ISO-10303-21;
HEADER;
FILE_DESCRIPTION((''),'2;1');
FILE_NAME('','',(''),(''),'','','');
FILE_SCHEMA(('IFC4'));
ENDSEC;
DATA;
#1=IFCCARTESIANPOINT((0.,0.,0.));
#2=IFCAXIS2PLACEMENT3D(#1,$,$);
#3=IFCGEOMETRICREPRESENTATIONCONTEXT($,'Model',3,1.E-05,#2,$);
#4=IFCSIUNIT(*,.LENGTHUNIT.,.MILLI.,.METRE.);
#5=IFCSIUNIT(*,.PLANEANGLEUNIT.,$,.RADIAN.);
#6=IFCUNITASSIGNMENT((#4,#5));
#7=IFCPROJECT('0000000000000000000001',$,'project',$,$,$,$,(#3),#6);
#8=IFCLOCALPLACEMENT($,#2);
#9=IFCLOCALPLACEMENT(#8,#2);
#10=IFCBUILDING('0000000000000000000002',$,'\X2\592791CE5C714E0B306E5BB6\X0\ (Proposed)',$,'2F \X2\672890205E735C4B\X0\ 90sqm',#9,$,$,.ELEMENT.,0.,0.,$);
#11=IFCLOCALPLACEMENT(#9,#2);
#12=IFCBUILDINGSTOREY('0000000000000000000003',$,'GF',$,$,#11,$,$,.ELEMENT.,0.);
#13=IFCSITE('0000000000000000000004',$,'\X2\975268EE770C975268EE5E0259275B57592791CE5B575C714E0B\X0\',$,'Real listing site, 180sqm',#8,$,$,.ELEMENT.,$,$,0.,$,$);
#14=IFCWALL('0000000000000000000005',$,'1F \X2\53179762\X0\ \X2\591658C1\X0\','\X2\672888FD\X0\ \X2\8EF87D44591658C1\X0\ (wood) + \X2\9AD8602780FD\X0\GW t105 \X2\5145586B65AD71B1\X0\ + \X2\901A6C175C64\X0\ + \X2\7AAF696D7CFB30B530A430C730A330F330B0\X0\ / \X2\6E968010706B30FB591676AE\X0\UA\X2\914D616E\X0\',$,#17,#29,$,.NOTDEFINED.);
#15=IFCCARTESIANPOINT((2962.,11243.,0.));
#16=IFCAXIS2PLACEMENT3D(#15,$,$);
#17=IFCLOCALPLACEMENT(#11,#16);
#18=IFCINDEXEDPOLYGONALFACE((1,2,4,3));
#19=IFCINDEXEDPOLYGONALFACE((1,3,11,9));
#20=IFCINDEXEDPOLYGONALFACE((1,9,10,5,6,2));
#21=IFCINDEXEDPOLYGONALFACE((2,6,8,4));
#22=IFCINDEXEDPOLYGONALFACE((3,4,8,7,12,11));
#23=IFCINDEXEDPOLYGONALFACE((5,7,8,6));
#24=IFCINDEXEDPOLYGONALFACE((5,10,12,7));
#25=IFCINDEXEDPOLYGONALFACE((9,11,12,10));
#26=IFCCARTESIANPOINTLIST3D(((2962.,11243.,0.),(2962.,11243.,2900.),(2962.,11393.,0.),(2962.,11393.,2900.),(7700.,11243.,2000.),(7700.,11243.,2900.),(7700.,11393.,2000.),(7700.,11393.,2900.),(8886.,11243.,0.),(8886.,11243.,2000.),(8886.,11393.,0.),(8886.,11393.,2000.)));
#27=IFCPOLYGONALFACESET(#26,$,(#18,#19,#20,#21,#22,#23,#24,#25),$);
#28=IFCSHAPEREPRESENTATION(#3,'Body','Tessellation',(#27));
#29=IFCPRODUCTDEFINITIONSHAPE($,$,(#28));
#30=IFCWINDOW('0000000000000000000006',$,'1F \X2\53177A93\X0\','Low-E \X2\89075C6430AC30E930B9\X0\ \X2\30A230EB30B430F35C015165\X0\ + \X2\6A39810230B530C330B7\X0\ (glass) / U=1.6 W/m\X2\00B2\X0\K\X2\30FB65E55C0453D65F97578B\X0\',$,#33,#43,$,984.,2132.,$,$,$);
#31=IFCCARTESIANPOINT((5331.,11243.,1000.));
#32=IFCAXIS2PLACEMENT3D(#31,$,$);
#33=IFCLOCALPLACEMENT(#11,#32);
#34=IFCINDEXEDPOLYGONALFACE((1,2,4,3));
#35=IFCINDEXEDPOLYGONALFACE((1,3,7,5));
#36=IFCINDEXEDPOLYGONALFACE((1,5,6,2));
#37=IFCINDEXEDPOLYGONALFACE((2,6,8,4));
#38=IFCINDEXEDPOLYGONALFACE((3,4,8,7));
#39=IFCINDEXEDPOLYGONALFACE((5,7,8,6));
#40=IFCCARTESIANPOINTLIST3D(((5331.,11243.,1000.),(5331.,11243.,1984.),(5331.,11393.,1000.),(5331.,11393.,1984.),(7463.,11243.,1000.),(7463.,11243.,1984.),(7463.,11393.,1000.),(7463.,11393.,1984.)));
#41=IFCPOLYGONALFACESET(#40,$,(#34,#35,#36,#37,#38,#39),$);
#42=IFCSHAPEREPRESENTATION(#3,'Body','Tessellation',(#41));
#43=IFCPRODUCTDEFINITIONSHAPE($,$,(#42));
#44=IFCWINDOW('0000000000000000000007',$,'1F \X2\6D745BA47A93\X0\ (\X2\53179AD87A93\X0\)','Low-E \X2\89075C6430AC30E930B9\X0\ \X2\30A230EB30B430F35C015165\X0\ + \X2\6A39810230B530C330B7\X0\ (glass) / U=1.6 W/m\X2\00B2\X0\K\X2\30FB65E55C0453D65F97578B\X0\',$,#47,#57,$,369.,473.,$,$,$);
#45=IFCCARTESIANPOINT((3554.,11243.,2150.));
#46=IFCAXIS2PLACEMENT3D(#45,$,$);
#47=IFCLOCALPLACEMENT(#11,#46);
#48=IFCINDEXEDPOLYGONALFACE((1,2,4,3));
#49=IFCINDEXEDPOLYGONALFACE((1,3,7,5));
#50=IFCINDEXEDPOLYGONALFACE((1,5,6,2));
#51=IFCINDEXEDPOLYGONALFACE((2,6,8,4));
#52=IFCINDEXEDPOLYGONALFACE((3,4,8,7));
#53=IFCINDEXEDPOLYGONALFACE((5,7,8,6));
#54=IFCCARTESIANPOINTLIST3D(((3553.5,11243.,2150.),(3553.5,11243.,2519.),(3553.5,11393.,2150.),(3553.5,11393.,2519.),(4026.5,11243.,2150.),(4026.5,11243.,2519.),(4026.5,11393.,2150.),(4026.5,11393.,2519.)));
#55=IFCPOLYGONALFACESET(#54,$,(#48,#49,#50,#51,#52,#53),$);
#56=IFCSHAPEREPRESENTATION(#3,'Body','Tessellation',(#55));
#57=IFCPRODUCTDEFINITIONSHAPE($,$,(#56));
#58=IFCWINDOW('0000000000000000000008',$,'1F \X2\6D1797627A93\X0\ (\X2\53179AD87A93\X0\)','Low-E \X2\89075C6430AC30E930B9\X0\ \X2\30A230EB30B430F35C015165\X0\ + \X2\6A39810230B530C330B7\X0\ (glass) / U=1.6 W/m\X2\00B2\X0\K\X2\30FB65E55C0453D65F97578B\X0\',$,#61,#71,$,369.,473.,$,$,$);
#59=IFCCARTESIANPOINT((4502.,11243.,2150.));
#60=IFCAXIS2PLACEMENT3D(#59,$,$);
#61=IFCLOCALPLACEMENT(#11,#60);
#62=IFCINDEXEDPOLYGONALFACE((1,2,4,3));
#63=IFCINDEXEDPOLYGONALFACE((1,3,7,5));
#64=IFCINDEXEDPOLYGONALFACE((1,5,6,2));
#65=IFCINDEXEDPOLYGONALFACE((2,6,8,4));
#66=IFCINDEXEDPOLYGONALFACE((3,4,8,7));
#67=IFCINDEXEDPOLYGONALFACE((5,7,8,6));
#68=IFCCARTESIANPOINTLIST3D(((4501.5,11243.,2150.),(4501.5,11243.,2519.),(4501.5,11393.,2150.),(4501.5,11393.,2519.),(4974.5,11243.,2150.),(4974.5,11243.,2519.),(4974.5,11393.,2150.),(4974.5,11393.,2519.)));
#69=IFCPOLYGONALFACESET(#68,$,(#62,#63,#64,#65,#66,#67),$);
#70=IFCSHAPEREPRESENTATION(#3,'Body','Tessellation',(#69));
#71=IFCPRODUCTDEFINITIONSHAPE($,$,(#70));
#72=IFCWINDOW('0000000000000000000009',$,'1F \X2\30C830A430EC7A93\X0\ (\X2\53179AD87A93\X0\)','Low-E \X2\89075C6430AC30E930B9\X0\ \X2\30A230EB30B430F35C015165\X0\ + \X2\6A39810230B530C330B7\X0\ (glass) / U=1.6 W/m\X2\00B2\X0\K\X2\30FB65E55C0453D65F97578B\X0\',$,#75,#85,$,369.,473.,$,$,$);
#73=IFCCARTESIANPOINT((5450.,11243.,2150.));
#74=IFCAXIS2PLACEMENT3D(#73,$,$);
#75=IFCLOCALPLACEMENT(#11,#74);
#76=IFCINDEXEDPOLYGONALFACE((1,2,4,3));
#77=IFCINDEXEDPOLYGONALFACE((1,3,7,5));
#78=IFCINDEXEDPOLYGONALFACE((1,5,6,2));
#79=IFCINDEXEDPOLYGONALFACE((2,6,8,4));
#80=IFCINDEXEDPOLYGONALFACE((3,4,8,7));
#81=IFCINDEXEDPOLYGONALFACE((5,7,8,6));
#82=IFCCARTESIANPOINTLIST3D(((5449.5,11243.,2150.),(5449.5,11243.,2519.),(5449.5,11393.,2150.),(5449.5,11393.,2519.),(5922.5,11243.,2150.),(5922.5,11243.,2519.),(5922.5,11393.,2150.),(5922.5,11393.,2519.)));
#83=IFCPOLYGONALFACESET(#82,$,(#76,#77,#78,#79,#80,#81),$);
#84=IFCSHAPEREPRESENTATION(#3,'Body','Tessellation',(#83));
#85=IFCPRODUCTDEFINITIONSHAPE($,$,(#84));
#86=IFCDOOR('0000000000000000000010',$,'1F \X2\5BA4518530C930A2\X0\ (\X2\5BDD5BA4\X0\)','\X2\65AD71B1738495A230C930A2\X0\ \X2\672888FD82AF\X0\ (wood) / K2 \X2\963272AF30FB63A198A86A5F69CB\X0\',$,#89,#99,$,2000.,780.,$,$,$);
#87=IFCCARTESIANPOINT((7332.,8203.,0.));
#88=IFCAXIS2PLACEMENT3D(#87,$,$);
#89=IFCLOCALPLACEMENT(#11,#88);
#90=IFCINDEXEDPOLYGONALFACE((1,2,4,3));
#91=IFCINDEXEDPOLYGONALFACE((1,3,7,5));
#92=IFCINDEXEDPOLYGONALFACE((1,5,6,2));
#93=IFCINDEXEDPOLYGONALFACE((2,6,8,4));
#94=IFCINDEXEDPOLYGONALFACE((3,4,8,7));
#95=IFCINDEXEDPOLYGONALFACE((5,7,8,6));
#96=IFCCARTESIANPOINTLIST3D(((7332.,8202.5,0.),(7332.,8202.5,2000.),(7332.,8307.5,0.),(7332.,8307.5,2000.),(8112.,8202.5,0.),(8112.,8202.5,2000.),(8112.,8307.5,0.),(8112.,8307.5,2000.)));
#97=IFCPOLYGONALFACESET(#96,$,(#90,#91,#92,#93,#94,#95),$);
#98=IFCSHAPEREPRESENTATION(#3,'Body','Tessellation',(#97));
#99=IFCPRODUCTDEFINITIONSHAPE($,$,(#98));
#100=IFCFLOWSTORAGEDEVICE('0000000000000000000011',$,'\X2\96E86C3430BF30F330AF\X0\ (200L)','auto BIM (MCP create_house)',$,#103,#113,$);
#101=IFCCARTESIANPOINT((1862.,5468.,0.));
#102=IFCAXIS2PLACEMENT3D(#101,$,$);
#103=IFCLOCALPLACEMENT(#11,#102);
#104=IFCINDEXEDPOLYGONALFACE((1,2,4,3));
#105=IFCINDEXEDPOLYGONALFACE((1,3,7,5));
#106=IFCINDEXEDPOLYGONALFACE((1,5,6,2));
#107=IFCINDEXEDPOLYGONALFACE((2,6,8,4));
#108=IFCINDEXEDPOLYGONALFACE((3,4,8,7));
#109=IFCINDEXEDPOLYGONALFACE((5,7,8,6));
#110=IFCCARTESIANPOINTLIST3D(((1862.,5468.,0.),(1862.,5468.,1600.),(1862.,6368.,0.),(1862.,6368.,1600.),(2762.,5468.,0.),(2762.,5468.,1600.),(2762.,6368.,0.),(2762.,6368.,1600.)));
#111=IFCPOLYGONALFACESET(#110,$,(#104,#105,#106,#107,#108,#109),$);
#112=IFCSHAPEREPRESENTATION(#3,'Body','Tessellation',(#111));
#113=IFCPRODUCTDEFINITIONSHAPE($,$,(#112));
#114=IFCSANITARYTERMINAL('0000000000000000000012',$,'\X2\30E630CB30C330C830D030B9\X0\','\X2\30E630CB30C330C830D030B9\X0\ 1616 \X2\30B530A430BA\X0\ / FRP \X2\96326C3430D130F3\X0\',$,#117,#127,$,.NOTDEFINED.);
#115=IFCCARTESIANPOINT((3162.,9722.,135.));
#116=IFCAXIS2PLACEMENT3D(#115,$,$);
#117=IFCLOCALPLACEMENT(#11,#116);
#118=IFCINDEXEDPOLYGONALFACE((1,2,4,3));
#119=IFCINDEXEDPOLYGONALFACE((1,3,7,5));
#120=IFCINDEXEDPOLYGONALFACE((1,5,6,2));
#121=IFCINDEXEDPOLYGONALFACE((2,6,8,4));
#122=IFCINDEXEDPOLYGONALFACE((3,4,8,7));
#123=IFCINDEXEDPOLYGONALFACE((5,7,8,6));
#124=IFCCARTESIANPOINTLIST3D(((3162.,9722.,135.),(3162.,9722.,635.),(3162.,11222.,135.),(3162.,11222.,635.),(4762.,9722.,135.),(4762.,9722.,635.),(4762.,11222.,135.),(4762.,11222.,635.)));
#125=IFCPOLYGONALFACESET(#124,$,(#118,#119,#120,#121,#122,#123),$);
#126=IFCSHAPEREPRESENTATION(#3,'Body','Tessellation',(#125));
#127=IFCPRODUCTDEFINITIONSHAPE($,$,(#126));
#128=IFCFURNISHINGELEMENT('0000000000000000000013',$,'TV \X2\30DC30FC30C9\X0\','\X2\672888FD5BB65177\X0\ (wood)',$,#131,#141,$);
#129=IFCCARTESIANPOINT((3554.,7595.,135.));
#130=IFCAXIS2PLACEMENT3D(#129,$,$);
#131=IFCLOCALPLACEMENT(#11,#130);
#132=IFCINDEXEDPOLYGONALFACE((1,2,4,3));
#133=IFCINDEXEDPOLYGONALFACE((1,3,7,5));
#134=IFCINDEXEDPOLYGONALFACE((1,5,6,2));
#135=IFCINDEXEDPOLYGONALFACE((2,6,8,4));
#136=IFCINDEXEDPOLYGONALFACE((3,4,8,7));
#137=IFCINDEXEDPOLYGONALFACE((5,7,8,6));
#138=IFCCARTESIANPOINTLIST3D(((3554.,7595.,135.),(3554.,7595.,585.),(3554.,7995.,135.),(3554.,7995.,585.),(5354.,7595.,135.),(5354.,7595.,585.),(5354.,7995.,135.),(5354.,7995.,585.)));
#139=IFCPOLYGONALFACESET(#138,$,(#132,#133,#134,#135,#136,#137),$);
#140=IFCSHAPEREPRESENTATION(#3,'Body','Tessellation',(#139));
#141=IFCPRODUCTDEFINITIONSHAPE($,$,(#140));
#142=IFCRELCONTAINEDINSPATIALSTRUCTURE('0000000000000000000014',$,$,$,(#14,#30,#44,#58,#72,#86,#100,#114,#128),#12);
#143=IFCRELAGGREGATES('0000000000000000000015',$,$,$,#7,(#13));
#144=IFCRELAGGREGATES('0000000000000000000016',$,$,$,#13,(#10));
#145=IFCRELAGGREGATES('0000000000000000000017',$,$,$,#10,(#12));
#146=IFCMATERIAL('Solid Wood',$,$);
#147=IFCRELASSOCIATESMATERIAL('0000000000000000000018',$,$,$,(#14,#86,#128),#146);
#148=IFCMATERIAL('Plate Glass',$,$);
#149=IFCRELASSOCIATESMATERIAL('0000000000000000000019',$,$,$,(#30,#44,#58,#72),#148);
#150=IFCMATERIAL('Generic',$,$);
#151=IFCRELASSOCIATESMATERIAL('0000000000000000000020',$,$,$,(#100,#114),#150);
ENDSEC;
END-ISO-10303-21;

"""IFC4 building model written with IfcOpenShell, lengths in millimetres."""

from ifc_helpers import new_model, si_unit, frame, frame_2d, origin, place, context, project, spatial, rectangle, extrude, material, element, fill, save


model = new_model("IFC4")

# Units and contexts
model_context = context("Model", 3, precision=1e-05, world=origin())
ifc_project = project(units=[si_unit("LENGTHUNIT", "METRE", prefix="MILLI"), si_unit("PLANEANGLEUNIT", "RADIAN")], contexts=[model_context])

# Site, building, storey
site_placement = place(None, origin())
site = spatial("IfcSite", under=ifc_project, at=site_placement, Name="青森県青森市大字大野字山下", ObjectType="Real listing site, 180sqm", CompositionType="ELEMENT", RefElevation=0.0)
building_placement = place(site_placement, origin())
building = spatial("IfcBuilding", under=site, at=building_placement, Name="大野山下の家 (Proposed)", ObjectType="2F 木造平屋 90sqm", CompositionType="ELEMENT", ElevationOfRefHeight=0.0, ElevationOfTerrain=0.0)
storey_placement = place(building_placement, origin())
storey = spatial("IfcBuildingStorey", under=building, at=storey_placement, Name="GF", CompositionType="ELEMENT", Elevation=0.0)

# Wall, openings, windows
ifc_material_1 = material(Name="Solid Wood")
wall_1_placement = place(storey_placement, frame((2962.0, 11243.0, 0.0)))
wall_1 = element("IfcWall", 1, at=wall_1_placement, inside=storey, material=ifc_material_1, Name="1F 北面 外壁", Description="木製 軸組外壁 (wood) + 高性能GW t105 充填断熱 + 通気層 + 窯業系サイディング / 準耐火・外皮UA配慮", PredefinedType="NOTDEFINED", context=model_context, shape_type="SweptSolid", body=[
    extrude(rectangle(XDim=5924.0, YDim=150.0, at=frame_2d((2962.0, 75.0))), frame((2962.0, 11243.0, 0.0)), (0.0, 0.0, 1.0), 2900.0),
])
opening_1_placement = place(storey_placement, frame((5331.0, 11243.0, 1000.0)))
opening_1 = element("IfcOpeningElement", 2, at=opening_1_placement, cuts=wall_1, PredefinedType="NOTDEFINED", context=model_context, shape_type="SweptSolid", body=[
    extrude(rectangle(XDim=2132.0, YDim=150.0, at=frame_2d((1066.0, 75.0))), frame((5331.0, 11243.0, 1000.0)), (0.0, 0.0, 1.0), 984.0),
])
opening_2_placement = place(storey_placement, frame((3554.0, 11243.0, 2150.0)))
opening_2 = element("IfcOpeningElement", 3, at=opening_2_placement, cuts=wall_1, PredefinedType="NOTDEFINED", context=model_context, shape_type="SweptSolid", body=[
    extrude(rectangle(XDim=473.0, YDim=150.0, at=frame_2d((236.0, 75.0))), frame((3554.0, 11243.0, 2150.0)), (0.0, 0.0, 1.0), 369.0),
])
opening_3_placement = place(storey_placement, frame((4502.0, 11243.0, 2150.0)))
opening_3 = element("IfcOpeningElement", 4, at=opening_3_placement, cuts=wall_1, PredefinedType="NOTDEFINED", context=model_context, shape_type="SweptSolid", body=[
    extrude(rectangle(XDim=473.0, YDim=150.0, at=frame_2d((236.0, 75.0))), frame((4502.0, 11243.0, 2150.0)), (0.0, 0.0, 1.0), 369.0),
])
opening_4_placement = place(storey_placement, frame((5450.0, 11243.0, 2150.0)))
opening_4 = element("IfcOpeningElement", 5, at=opening_4_placement, cuts=wall_1, PredefinedType="NOTDEFINED", context=model_context, shape_type="SweptSolid", body=[
    extrude(rectangle(XDim=473.0, YDim=150.0, at=frame_2d((236.0, 75.0))), frame((5450.0, 11243.0, 2150.0)), (0.0, 0.0, 1.0), 369.0),
])
ifc_material_2 = material(Name="Plate Glass")
window_1_placement = place(storey_placement, frame((5331.0, 11243.0, 1000.0)))
window_1 = element("IfcWindow", 6, at=window_1_placement, inside=storey, material=ifc_material_2, Name="1F 北窓", Description="Low-E 複層ガラス アルゴン封入 + 樹脂サッシ (glass) / U=1.6 W/m²K・日射取得型", OverallHeight=984.0, OverallWidth=2132.0, context=model_context, shape_type="SweptSolid", body=[
    extrude(rectangle(XDim=2132.0, YDim=150.0, at=frame_2d((1066.0, 75.0))), frame((5331.0, 11243.0, 1000.0)), (0.0, 0.0, 1.0), 984.0),
])
fill(opening_1, window_1)
window_2_placement = place(storey_placement, frame((3554.0, 11243.0, 2150.0)))
window_2 = element("IfcWindow", 7, at=window_2_placement, inside=storey, material=ifc_material_2, Name="1F 浴室窓 (北高窓)", Description="Low-E 複層ガラス アルゴン封入 + 樹脂サッシ (glass) / U=1.6 W/m²K・日射取得型", OverallHeight=369.0, OverallWidth=473.0, context=model_context, shape_type="SweptSolid", body=[
    extrude(rectangle(XDim=473.0, YDim=150.0, at=frame_2d((236.0, 75.0))), frame((3554.0, 11243.0, 2150.0)), (0.0, 0.0, 1.0), 369.0),
])
fill(opening_2, window_2)
window_3_placement = place(storey_placement, frame((4502.0, 11243.0, 2150.0)))
window_3 = element("IfcWindow", 8, at=window_3_placement, inside=storey, material=ifc_material_2, Name="1F 洗面窓 (北高窓)", Description="Low-E 複層ガラス アルゴン封入 + 樹脂サッシ (glass) / U=1.6 W/m²K・日射取得型", OverallHeight=369.0, OverallWidth=473.0, context=model_context, shape_type="SweptSolid", body=[
    extrude(rectangle(XDim=473.0, YDim=150.0, at=frame_2d((236.0, 75.0))), frame((4502.0, 11243.0, 2150.0)), (0.0, 0.0, 1.0), 369.0),
])
fill(opening_3, window_3)
window_4_placement = place(storey_placement, frame((5450.0, 11243.0, 2150.0)))
window_4 = element("IfcWindow", 9, at=window_4_placement, inside=storey, material=ifc_material_2, Name="1F トイレ窓 (北高窓)", Description="Low-E 複層ガラス アルゴン封入 + 樹脂サッシ (glass) / U=1.6 W/m²K・日射取得型", OverallHeight=369.0, OverallWidth=473.0, context=model_context, shape_type="SweptSolid", body=[
    extrude(rectangle(XDim=473.0, YDim=150.0, at=frame_2d((236.0, 75.0))), frame((5450.0, 11243.0, 2150.0)), (0.0, 0.0, 1.0), 369.0),
])
fill(opening_4, window_4)

# Door
door_1_placement = place(storey_placement, frame((7332.0, 8203.0, 0.0)))
element("IfcDoor", 10, at=door_1_placement, inside=storey, material=ifc_material_1, Name="1F 室内ドア (寝室)", Description="断熱玄関ドア 木製芯 (wood) / K2 防犯・採風機構", OverallHeight=2000.0, OverallWidth=780.0, context=model_context, shape_type="SweptSolid", body=[
    extrude(rectangle(XDim=780.0, YDim=105.0, at=frame_2d((390.0, 52.0))), frame((7332.0, 8203.0, 0.0)), (0.0, 0.0, 1.0), 2000.0),
])

# Flow storage device
ifc_material_3 = material(Name="Generic")
flow_storage_device_placement = place(storey_placement, frame((1862.0, 5468.0, 0.0)))
element("IfcFlowStorageDevice", 11, at=flow_storage_device_placement, inside=storey, material=ifc_material_3, Name="雨水タンク (200L)", Description="auto BIM (MCP create_house)", context=model_context, shape_type="SweptSolid", body=[
    extrude(rectangle(XDim=900.0, YDim=900.0, at=frame_2d((450.0, 450.0))), frame((1862.0, 5468.0, 0.0)), (0.0, 0.0, 1.0), 1600.0),
])

# Sanitary terminal
sanitary_terminal_placement = place(storey_placement, frame((3162.0, 9722.0, 135.0)))
element("IfcSanitaryTerminal", 12, at=sanitary_terminal_placement, inside=storey, material=ifc_material_3, Name="ユニットバス", Description="ユニットバス 1616 サイズ / FRP 防水パン", PredefinedType="NOTDEFINED", context=model_context, shape_type="SweptSolid", body=[
    extrude(rectangle(XDim=1600.0, YDim=1500.0, at=frame_2d((800.0, 750.0))), frame((3162.0, 9722.0, 135.0)), (0.0, 0.0, 1.0), 500.0),
])

# Furnishing element
furnishing_placement = place(storey_placement, frame((3554.0, 7595.0, 135.0)))
element("IfcFurnishingElement", 13, at=furnishing_placement, inside=storey, material=ifc_material_1, Name="TV ボード", Description="木製家具 (wood)", context=model_context, shape_type="SweptSolid", body=[
    extrude(rectangle(XDim=1800.0, YDim=400.0, at=frame_2d((900.0, 200.0))), frame((3554.0, 7595.0, 135.0)), (0.0, 0.0, 1.0), 450.0),
])

save(model, "model.ifc")
